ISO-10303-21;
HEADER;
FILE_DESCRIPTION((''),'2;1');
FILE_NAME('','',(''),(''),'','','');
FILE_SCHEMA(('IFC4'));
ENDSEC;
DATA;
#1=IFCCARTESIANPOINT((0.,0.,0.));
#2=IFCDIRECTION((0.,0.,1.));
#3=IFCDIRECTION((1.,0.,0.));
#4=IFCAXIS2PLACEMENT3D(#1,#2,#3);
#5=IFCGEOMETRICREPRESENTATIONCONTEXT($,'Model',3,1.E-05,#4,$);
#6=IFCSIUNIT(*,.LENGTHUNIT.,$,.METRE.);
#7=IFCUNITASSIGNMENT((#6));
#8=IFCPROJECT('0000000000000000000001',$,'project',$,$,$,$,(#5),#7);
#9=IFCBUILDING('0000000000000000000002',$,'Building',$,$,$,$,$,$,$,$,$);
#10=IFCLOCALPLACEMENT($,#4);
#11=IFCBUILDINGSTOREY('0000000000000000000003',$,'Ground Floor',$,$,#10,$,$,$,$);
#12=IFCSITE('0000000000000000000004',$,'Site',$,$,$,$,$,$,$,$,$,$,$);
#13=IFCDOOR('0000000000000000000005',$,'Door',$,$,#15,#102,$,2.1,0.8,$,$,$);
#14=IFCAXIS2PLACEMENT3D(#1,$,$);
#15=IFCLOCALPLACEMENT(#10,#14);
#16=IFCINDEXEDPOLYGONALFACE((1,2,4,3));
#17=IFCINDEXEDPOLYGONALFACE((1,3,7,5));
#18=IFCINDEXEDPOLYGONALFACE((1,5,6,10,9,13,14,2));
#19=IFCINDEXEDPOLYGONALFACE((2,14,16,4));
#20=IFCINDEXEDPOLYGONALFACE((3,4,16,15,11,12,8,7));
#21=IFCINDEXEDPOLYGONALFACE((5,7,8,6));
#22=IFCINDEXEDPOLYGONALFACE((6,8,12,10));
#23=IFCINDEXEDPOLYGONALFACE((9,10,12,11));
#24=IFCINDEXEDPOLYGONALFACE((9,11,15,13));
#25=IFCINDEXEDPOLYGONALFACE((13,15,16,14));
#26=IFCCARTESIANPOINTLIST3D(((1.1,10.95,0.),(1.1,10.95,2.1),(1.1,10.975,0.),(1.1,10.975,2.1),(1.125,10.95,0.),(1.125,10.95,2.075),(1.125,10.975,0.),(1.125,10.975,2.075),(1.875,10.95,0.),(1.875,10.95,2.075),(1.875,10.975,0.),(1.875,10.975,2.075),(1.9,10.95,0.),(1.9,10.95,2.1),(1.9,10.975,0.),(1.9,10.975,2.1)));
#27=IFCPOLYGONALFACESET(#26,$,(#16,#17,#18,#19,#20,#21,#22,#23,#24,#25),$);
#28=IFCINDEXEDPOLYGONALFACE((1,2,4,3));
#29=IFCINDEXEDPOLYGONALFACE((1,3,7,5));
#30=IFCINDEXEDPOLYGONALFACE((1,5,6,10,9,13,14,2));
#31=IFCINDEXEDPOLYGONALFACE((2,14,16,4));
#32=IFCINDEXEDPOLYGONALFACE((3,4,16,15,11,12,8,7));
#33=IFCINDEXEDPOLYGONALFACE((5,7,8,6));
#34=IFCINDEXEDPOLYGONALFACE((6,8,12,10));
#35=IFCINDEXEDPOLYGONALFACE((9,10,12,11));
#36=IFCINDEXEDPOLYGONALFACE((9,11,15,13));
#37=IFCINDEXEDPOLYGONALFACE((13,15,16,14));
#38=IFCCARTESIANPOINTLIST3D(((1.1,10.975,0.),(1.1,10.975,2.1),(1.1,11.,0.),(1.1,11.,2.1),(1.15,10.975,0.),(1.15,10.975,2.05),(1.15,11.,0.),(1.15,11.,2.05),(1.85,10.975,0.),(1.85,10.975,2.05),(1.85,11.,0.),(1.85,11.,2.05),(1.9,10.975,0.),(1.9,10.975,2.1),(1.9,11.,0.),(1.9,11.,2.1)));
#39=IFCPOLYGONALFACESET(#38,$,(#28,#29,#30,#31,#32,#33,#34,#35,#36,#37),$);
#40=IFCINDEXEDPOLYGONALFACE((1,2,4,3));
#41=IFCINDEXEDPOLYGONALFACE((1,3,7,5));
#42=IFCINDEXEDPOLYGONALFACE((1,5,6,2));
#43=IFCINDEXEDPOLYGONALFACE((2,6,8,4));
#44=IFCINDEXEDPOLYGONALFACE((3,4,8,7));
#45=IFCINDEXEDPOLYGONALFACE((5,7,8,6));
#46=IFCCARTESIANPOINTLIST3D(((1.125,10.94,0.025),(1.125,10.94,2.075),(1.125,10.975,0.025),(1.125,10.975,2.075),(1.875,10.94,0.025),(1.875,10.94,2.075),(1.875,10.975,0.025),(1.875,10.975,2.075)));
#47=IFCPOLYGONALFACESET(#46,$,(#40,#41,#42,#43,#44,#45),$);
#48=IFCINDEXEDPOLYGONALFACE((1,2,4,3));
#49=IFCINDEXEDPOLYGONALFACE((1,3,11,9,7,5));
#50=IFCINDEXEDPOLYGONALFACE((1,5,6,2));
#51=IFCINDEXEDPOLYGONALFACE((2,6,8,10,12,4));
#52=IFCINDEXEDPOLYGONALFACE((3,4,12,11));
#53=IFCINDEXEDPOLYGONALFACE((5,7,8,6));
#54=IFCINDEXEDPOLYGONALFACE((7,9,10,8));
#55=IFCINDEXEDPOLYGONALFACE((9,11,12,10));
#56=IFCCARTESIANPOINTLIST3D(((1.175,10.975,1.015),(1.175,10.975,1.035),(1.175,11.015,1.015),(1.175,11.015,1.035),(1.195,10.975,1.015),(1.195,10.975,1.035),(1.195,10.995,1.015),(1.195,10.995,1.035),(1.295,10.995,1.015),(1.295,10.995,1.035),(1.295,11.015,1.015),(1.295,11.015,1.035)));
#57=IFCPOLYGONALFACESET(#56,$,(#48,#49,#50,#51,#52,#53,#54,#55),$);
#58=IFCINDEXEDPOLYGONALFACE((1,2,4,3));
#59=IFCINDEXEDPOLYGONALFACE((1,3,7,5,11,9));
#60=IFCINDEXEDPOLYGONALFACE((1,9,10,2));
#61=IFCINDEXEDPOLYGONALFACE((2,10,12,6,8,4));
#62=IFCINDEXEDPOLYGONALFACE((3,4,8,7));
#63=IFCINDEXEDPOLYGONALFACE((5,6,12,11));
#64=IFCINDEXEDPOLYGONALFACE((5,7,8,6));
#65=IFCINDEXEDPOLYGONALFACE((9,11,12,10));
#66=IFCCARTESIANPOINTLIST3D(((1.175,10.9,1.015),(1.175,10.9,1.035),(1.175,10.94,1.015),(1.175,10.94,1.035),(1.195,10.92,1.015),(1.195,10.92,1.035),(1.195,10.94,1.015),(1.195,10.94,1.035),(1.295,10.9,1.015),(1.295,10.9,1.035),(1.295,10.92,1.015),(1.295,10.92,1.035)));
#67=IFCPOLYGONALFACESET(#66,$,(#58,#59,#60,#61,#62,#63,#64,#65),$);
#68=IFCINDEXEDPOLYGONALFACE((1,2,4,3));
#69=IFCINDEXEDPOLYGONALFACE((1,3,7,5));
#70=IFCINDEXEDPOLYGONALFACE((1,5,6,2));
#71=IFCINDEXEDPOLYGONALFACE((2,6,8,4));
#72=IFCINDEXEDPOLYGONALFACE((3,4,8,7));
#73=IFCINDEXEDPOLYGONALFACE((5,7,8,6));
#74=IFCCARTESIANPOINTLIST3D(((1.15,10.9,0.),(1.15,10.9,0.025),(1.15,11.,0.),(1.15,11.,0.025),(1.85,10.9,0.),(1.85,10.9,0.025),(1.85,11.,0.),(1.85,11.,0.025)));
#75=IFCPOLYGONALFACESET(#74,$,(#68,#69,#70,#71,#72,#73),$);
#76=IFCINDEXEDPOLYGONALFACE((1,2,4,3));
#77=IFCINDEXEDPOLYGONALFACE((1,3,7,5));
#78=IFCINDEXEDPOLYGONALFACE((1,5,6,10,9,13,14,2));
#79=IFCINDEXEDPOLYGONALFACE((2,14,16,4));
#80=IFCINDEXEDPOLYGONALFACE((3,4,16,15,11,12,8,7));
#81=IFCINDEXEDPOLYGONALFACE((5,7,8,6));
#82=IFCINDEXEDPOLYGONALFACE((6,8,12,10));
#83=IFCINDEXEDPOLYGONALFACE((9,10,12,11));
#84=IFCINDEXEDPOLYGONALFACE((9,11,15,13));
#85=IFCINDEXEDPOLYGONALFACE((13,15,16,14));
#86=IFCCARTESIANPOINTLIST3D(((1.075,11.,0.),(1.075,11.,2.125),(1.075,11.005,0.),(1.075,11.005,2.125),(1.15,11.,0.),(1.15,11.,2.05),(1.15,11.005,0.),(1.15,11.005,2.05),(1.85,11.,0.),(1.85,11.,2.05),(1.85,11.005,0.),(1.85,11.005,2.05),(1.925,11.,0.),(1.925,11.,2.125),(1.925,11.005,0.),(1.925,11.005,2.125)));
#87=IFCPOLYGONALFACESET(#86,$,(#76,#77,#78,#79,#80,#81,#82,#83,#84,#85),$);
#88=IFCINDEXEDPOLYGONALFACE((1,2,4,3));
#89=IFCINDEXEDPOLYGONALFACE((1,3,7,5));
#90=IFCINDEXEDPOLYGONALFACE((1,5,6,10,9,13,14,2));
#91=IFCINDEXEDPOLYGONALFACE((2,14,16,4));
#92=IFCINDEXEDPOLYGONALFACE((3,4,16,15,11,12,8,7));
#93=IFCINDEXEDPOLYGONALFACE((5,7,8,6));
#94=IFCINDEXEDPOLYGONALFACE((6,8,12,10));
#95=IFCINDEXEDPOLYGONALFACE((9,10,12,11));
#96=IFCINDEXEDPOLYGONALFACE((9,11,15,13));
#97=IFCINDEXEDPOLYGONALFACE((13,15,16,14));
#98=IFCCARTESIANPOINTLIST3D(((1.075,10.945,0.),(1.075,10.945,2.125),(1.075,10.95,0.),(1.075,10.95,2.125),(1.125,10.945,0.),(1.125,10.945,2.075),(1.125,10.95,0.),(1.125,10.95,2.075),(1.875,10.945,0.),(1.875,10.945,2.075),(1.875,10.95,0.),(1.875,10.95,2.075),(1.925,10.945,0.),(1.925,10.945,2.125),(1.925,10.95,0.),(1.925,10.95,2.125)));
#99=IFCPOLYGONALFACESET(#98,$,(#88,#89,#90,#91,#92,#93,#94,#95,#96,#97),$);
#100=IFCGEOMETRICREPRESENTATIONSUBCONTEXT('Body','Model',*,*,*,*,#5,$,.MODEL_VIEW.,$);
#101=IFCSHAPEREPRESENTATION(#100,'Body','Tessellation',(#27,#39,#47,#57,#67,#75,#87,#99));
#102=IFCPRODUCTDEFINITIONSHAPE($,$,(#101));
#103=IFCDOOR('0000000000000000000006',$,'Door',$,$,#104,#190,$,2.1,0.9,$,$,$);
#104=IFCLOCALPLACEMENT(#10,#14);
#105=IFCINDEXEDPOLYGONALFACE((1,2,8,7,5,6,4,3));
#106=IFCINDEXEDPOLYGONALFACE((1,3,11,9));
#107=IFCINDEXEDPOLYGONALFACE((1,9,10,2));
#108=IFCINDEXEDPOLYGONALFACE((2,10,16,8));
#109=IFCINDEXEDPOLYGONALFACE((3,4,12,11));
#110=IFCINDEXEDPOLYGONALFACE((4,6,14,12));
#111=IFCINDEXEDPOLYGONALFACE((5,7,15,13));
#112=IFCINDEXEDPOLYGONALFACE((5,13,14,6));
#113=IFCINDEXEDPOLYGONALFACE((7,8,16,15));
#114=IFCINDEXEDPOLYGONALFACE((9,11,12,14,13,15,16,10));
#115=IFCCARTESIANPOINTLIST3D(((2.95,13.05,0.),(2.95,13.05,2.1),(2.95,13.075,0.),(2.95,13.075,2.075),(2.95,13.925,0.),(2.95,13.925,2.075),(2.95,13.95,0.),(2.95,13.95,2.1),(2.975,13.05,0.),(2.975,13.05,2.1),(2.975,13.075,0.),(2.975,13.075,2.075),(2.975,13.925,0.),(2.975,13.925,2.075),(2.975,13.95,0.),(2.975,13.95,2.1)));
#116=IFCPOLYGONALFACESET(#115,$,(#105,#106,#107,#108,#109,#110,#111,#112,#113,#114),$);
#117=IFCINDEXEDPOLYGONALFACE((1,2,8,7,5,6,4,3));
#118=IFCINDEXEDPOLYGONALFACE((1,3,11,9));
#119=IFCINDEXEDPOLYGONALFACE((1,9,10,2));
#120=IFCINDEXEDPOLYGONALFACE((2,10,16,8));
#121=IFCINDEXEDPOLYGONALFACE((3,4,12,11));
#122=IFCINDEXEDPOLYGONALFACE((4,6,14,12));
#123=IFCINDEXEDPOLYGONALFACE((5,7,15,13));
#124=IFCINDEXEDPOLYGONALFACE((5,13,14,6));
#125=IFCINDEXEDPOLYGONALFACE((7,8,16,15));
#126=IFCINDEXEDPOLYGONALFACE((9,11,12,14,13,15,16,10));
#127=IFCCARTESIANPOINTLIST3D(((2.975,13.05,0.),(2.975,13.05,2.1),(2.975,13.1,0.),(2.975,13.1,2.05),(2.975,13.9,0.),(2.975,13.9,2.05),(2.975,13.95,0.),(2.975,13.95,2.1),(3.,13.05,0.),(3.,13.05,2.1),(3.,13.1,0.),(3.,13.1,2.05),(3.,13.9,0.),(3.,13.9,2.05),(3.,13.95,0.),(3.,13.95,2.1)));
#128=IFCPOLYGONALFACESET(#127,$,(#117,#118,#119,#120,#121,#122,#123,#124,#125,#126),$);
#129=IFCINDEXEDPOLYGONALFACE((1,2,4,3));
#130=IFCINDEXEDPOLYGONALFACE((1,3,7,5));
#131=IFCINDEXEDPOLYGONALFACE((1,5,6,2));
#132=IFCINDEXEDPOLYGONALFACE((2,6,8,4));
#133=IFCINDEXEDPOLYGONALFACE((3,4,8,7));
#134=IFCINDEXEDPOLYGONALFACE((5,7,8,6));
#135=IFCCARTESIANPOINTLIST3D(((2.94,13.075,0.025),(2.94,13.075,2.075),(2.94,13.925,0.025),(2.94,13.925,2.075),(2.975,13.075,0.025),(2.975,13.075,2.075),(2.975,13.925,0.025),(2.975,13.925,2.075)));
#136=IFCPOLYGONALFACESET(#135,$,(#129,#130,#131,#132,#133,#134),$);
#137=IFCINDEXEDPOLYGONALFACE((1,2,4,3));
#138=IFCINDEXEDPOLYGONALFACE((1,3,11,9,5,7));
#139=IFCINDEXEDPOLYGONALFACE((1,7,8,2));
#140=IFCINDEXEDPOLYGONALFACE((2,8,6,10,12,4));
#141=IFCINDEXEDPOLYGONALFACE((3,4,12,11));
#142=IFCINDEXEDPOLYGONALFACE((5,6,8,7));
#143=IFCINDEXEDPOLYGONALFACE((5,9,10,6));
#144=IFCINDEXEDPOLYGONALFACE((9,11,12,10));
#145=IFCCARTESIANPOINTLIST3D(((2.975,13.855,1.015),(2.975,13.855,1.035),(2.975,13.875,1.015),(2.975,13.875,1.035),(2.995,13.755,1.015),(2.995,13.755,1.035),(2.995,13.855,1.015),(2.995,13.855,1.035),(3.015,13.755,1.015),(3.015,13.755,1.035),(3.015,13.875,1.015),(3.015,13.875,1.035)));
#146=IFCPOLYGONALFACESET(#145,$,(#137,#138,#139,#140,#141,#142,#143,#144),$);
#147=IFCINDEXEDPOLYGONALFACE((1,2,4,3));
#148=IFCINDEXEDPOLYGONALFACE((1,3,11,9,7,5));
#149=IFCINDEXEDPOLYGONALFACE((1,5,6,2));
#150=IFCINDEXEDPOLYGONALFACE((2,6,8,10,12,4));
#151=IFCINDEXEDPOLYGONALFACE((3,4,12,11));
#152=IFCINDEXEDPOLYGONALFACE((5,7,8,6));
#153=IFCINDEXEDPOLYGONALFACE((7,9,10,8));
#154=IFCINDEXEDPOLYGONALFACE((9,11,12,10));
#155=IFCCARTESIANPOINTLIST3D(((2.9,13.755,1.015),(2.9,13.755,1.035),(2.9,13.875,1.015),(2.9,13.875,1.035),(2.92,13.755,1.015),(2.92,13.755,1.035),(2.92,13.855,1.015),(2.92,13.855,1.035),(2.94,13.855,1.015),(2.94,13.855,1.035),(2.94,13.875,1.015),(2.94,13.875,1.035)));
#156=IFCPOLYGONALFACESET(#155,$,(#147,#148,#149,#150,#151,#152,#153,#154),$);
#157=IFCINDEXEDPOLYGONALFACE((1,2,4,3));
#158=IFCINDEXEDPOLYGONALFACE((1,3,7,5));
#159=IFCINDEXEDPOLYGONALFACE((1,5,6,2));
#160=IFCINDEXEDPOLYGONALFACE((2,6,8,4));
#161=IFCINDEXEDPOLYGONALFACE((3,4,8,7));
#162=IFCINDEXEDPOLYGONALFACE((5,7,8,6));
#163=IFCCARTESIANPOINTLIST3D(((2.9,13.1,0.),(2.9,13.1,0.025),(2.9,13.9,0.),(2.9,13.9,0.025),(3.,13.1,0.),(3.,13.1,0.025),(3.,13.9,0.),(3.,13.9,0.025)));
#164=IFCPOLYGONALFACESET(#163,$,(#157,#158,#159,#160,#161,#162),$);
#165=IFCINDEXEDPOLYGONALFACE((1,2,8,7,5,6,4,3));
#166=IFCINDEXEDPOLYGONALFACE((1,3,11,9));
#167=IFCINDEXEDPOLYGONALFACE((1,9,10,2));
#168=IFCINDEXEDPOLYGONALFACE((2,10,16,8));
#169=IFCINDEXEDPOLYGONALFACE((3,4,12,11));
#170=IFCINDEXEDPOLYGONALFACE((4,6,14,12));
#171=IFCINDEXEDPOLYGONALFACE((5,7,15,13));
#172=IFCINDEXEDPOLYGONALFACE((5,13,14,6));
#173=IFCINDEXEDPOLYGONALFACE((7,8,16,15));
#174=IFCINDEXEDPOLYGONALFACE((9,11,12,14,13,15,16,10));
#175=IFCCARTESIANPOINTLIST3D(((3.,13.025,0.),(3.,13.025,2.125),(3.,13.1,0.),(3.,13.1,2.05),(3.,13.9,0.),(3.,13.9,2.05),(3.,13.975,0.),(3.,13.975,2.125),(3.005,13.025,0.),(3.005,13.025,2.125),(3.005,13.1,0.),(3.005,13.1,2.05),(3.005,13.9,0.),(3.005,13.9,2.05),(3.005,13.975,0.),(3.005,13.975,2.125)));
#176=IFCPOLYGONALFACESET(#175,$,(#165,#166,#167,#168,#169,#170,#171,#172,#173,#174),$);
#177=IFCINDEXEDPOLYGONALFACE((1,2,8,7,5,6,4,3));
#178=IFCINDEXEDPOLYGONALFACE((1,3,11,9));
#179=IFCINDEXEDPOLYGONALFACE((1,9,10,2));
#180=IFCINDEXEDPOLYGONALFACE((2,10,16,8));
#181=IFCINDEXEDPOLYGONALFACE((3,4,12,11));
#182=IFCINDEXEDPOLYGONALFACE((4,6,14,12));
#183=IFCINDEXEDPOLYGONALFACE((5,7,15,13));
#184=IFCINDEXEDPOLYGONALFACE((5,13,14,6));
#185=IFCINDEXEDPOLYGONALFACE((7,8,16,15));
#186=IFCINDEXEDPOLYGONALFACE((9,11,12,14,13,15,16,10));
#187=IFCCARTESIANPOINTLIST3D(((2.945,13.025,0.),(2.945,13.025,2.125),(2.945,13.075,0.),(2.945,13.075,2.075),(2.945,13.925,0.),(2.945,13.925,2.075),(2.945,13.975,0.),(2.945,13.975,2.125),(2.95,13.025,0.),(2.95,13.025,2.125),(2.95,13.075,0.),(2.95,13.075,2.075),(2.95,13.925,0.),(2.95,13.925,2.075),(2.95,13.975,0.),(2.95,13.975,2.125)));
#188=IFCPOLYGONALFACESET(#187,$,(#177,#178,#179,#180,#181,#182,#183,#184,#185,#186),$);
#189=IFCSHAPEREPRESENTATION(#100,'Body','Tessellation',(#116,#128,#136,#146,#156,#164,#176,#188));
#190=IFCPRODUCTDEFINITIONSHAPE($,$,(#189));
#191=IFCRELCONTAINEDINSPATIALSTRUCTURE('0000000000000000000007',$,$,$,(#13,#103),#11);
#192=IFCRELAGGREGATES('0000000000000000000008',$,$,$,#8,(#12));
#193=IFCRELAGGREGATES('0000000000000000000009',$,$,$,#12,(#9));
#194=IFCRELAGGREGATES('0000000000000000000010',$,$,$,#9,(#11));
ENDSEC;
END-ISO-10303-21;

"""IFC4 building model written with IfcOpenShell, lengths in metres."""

from ifc_helpers import new_model, si_unit, frame, origin_with_axes, place, context, subcontext, project, spatial, line, indexed_curve, outline, extrude, element, save


model = new_model("IFC4")

# Units and contexts
model_context = context("Model", 3, precision=1e-05, world=origin_with_axes())
body_context = subcontext(model_context, "Body", "Model", "MODEL_VIEW")
ifc_project = project(units=[si_unit("LENGTHUNIT", "METRE")], contexts=[model_context])

# Site, building, storey
site = spatial("IfcSite", under=ifc_project, Name="Site")
building = spatial("IfcBuilding", under=site, Name="Building")
storey_placement = place(None, origin_with_axes())
storey = spatial("IfcBuildingStorey", under=building, at=storey_placement, Name="Ground Floor")

# Doors
door_1_placement = place(storey_placement, frame((1.9, 11.0, 0.0), z_axis=(0.0, 0.0, 1.0), x_axis=(-1.0, 0.0, 0.0)))
element("IfcDoor", 1, at=door_1_placement, inside=storey, Name="Door", OverallHeight=2.1, OverallWidth=0.8, context=body_context, shape_type="SweptSolid", body=[
    extrude(outline(indexed_curve([(0.0, 0.0), (0.0, 2.1), (0.8, 2.1), (0.8, 0.0), (0.775, 0.0), (0.775, 2.075), (0.025, 2.075), (0.025, 0.0)], segments=[line(1, 2, 3, 4, 5, 6, 7, 8, 1)])), frame((0.0, 0.025, 0.0), z_axis=(0.0, -1.0, 0.0), x_axis=(1.0, 0.0, 0.0)), (0.0, 0.0, -1.0), 0.025),
    extrude(outline(indexed_curve([(0.0, 0.0), (0.0, 2.1), (0.8, 2.1), (0.8, 0.0), (0.75, 0.0), (0.75, 2.05), (0.05, 2.05), (0.05, 0.0)], segments=[line(1, 2, 3, 4, 5, 6, 7, 8, 1)])), frame((0.0, 0.0, 0.0), z_axis=(0.0, -1.0, 0.0), x_axis=(1.0, 0.0, 0.0)), (0.0, 0.0, -1.0), 0.025),
    extrude(outline(indexed_curve([(0.0, 0.0), (0.75, 0.0), (0.75, 0.035), (0.0, 0.035)], segments=[line(1, 2, 3, 4, 1)])), frame((0.025, 0.025, 0.025), z_axis=(0.0, 0.0, 1.0), x_axis=(1.0, 0.0, 0.0)), (0.0, 0.0, 1.0), 2.05),
    extrude(outline(indexed_curve([(0.0, 0.0), (0.0, -0.04), (-0.12, -0.04), (-0.12, -0.02), (-0.02, -0.02), (-0.02, 0.0)], segments=[line(1, 2, 3, 4, 5, 6, 1)])), frame((0.725, 0.025, 1.015), z_axis=(0.0, 0.0, 1.0), x_axis=(1.0, 0.0, 0.0)), (0.0, 0.0, 1.0), 0.02),
    extrude(outline(indexed_curve([(0.0, 0.0), (0.0, 0.04), (-0.12, 0.04), (-0.12, 0.02), (-0.02, 0.02), (-0.02, 0.0)], segments=[line(1, 2, 3, 4, 5, 6, 1)])), frame((0.725, 0.06, 1.015), z_axis=(0.0, 0.0, 1.0), x_axis=(1.0, 0.0, 0.0)), (0.0, 0.0, 1.0), 0.02),
    extrude(outline(indexed_curve([(0.0, 0.0), (0.7, 0.0), (0.7, 0.1), (0.0, 0.1)], segments=[line(1, 2, 3, 4, 1)])), frame((0.05, 0.0, 0.0), z_axis=(0.0, 0.0, 1.0), x_axis=(1.0, 0.0, 0.0)), (0.0, 0.0, 1.0), 0.025),
    extrude(outline(indexed_curve([(0.0, 0.0), (0.0, 2.125), (0.85, 2.125), (0.85, 0.0), (0.775, 0.0), (0.775, 2.05), (0.075, 2.05), (0.075, 0.0)], segments=[line(1, 2, 3, 4, 5, 6, 7, 8, 1)])), frame((-0.025, -0.005, 0.0), z_axis=(0.0, -1.0, 0.0), x_axis=(1.0, 0.0, 0.0)), (0.0, 0.0, -1.0), 0.005),
    extrude(outline(indexed_curve([(0.0, 0.0), (0.0, 2.125), (0.85, 2.125), (0.85, 0.0), (0.8, 0.0), (0.8, 2.075), (0.05, 2.075), (0.05, 0.0)], segments=[line(1, 2, 3, 4, 5, 6, 7, 8, 1)])), frame((-0.025, 0.05, 0.0), z_axis=(0.0, -1.0, 0.0), x_axis=(1.0, 0.0, 0.0)), (0.0, 0.0, -1.0), 0.005),
])
door_2_placement = place(storey_placement, frame((3.0, 13.05, 0.0), z_axis=(0.0, 0.0, 1.0), x_axis=(0.0, 1.0, 0.0)))
element("IfcDoor", 2, at=door_2_placement, inside=storey, Name="Door", OverallHeight=2.1, OverallWidth=0.9, context=body_context, shape_type="SweptSolid", body=[
    extrude(outline(indexed_curve([(0.0, 0.0), (0.0, 2.1), (0.9, 2.1), (0.9, 0.0), (0.875, 0.0), (0.875, 2.075), (0.025, 2.075), (0.025, 0.0)], segments=[line(1, 2, 3, 4, 5, 6, 7, 8, 1)])), frame((0.0, 0.025, 0.0), z_axis=(0.0, -1.0, 0.0), x_axis=(1.0, 0.0, 0.0)), (0.0, 0.0, -1.0), 0.025),
    extrude(outline(indexed_curve([(0.0, 0.0), (0.0, 2.1), (0.9, 2.1), (0.9, 0.0), (0.85, 0.0), (0.85, 2.05), (0.05, 2.05), (0.05, 0.0)], segments=[line(1, 2, 3, 4, 5, 6, 7, 8, 1)])), frame((0.0, 0.0, 0.0), z_axis=(0.0, -1.0, 0.0), x_axis=(1.0, 0.0, 0.0)), (0.0, 0.0, -1.0), 0.025),
    extrude(outline(indexed_curve([(0.0, 0.0), (0.85, 0.0), (0.85, 0.035), (0.0, 0.035)], segments=[line(1, 2, 3, 4, 1)])), frame((0.025, 0.025, 0.025), z_axis=(0.0, 0.0, 1.0), x_axis=(1.0, 0.0, 0.0)), (0.0, 0.0, 1.0), 2.05),
    extrude(outline(indexed_curve([(0.0, 0.0), (0.0, -0.04), (-0.12, -0.04), (-0.12, -0.02), (-0.02, -0.02), (-0.02, 0.0)], segments=[line(1, 2, 3, 4, 5, 6, 1)])), frame((0.825, 0.025, 1.015), z_axis=(0.0, 0.0, 1.0), x_axis=(1.0, 0.0, 0.0)), (0.0, 0.0, 1.0), 0.02),
    extrude(outline(indexed_curve([(0.0, 0.0), (0.0, 0.04), (-0.12, 0.04), (-0.12, 0.02), (-0.02, 0.02), (-0.02, 0.0)], segments=[line(1, 2, 3, 4, 5, 6, 1)])), frame((0.825, 0.06, 1.015), z_axis=(0.0, 0.0, 1.0), x_axis=(1.0, 0.0, 0.0)), (0.0, 0.0, 1.0), 0.02),
    extrude(outline(indexed_curve([(0.0, 0.0), (0.8, 0.0), (0.8, 0.1), (0.0, 0.1)], segments=[line(1, 2, 3, 4, 1)])), frame((0.05, 0.0, 0.0), z_axis=(0.0, 0.0, 1.0), x_axis=(1.0, 0.0, 0.0)), (0.0, 0.0, 1.0), 0.025),
    extrude(outline(indexed_curve([(0.0, 0.0), (0.0, 2.125), (0.95, 2.125), (0.95, 0.0), (0.875, 0.0), (0.875, 2.05), (0.075, 2.05), (0.075, 0.0)], segments=[line(1, 2, 3, 4, 5, 6, 7, 8, 1)])), frame((-0.025, -0.005, 0.0), z_axis=(0.0, -1.0, 0.0), x_axis=(1.0, 0.0, 0.0)), (0.0, 0.0, -1.0), 0.005),
    extrude(outline(indexed_curve([(0.0, 0.0), (0.0, 2.125), (0.95, 2.125), (0.95, 0.0), (0.9, 0.0), (0.9, 2.075), (0.05, 2.075), (0.05, 0.0)], segments=[line(1, 2, 3, 4, 5, 6, 7, 8, 1)])), frame((-0.025, 0.05, 0.0), z_axis=(0.0, -1.0, 0.0), x_axis=(1.0, 0.0, 0.0)), (0.0, 0.0, -1.0), 0.005),
])

save(model, "model.ifc")
